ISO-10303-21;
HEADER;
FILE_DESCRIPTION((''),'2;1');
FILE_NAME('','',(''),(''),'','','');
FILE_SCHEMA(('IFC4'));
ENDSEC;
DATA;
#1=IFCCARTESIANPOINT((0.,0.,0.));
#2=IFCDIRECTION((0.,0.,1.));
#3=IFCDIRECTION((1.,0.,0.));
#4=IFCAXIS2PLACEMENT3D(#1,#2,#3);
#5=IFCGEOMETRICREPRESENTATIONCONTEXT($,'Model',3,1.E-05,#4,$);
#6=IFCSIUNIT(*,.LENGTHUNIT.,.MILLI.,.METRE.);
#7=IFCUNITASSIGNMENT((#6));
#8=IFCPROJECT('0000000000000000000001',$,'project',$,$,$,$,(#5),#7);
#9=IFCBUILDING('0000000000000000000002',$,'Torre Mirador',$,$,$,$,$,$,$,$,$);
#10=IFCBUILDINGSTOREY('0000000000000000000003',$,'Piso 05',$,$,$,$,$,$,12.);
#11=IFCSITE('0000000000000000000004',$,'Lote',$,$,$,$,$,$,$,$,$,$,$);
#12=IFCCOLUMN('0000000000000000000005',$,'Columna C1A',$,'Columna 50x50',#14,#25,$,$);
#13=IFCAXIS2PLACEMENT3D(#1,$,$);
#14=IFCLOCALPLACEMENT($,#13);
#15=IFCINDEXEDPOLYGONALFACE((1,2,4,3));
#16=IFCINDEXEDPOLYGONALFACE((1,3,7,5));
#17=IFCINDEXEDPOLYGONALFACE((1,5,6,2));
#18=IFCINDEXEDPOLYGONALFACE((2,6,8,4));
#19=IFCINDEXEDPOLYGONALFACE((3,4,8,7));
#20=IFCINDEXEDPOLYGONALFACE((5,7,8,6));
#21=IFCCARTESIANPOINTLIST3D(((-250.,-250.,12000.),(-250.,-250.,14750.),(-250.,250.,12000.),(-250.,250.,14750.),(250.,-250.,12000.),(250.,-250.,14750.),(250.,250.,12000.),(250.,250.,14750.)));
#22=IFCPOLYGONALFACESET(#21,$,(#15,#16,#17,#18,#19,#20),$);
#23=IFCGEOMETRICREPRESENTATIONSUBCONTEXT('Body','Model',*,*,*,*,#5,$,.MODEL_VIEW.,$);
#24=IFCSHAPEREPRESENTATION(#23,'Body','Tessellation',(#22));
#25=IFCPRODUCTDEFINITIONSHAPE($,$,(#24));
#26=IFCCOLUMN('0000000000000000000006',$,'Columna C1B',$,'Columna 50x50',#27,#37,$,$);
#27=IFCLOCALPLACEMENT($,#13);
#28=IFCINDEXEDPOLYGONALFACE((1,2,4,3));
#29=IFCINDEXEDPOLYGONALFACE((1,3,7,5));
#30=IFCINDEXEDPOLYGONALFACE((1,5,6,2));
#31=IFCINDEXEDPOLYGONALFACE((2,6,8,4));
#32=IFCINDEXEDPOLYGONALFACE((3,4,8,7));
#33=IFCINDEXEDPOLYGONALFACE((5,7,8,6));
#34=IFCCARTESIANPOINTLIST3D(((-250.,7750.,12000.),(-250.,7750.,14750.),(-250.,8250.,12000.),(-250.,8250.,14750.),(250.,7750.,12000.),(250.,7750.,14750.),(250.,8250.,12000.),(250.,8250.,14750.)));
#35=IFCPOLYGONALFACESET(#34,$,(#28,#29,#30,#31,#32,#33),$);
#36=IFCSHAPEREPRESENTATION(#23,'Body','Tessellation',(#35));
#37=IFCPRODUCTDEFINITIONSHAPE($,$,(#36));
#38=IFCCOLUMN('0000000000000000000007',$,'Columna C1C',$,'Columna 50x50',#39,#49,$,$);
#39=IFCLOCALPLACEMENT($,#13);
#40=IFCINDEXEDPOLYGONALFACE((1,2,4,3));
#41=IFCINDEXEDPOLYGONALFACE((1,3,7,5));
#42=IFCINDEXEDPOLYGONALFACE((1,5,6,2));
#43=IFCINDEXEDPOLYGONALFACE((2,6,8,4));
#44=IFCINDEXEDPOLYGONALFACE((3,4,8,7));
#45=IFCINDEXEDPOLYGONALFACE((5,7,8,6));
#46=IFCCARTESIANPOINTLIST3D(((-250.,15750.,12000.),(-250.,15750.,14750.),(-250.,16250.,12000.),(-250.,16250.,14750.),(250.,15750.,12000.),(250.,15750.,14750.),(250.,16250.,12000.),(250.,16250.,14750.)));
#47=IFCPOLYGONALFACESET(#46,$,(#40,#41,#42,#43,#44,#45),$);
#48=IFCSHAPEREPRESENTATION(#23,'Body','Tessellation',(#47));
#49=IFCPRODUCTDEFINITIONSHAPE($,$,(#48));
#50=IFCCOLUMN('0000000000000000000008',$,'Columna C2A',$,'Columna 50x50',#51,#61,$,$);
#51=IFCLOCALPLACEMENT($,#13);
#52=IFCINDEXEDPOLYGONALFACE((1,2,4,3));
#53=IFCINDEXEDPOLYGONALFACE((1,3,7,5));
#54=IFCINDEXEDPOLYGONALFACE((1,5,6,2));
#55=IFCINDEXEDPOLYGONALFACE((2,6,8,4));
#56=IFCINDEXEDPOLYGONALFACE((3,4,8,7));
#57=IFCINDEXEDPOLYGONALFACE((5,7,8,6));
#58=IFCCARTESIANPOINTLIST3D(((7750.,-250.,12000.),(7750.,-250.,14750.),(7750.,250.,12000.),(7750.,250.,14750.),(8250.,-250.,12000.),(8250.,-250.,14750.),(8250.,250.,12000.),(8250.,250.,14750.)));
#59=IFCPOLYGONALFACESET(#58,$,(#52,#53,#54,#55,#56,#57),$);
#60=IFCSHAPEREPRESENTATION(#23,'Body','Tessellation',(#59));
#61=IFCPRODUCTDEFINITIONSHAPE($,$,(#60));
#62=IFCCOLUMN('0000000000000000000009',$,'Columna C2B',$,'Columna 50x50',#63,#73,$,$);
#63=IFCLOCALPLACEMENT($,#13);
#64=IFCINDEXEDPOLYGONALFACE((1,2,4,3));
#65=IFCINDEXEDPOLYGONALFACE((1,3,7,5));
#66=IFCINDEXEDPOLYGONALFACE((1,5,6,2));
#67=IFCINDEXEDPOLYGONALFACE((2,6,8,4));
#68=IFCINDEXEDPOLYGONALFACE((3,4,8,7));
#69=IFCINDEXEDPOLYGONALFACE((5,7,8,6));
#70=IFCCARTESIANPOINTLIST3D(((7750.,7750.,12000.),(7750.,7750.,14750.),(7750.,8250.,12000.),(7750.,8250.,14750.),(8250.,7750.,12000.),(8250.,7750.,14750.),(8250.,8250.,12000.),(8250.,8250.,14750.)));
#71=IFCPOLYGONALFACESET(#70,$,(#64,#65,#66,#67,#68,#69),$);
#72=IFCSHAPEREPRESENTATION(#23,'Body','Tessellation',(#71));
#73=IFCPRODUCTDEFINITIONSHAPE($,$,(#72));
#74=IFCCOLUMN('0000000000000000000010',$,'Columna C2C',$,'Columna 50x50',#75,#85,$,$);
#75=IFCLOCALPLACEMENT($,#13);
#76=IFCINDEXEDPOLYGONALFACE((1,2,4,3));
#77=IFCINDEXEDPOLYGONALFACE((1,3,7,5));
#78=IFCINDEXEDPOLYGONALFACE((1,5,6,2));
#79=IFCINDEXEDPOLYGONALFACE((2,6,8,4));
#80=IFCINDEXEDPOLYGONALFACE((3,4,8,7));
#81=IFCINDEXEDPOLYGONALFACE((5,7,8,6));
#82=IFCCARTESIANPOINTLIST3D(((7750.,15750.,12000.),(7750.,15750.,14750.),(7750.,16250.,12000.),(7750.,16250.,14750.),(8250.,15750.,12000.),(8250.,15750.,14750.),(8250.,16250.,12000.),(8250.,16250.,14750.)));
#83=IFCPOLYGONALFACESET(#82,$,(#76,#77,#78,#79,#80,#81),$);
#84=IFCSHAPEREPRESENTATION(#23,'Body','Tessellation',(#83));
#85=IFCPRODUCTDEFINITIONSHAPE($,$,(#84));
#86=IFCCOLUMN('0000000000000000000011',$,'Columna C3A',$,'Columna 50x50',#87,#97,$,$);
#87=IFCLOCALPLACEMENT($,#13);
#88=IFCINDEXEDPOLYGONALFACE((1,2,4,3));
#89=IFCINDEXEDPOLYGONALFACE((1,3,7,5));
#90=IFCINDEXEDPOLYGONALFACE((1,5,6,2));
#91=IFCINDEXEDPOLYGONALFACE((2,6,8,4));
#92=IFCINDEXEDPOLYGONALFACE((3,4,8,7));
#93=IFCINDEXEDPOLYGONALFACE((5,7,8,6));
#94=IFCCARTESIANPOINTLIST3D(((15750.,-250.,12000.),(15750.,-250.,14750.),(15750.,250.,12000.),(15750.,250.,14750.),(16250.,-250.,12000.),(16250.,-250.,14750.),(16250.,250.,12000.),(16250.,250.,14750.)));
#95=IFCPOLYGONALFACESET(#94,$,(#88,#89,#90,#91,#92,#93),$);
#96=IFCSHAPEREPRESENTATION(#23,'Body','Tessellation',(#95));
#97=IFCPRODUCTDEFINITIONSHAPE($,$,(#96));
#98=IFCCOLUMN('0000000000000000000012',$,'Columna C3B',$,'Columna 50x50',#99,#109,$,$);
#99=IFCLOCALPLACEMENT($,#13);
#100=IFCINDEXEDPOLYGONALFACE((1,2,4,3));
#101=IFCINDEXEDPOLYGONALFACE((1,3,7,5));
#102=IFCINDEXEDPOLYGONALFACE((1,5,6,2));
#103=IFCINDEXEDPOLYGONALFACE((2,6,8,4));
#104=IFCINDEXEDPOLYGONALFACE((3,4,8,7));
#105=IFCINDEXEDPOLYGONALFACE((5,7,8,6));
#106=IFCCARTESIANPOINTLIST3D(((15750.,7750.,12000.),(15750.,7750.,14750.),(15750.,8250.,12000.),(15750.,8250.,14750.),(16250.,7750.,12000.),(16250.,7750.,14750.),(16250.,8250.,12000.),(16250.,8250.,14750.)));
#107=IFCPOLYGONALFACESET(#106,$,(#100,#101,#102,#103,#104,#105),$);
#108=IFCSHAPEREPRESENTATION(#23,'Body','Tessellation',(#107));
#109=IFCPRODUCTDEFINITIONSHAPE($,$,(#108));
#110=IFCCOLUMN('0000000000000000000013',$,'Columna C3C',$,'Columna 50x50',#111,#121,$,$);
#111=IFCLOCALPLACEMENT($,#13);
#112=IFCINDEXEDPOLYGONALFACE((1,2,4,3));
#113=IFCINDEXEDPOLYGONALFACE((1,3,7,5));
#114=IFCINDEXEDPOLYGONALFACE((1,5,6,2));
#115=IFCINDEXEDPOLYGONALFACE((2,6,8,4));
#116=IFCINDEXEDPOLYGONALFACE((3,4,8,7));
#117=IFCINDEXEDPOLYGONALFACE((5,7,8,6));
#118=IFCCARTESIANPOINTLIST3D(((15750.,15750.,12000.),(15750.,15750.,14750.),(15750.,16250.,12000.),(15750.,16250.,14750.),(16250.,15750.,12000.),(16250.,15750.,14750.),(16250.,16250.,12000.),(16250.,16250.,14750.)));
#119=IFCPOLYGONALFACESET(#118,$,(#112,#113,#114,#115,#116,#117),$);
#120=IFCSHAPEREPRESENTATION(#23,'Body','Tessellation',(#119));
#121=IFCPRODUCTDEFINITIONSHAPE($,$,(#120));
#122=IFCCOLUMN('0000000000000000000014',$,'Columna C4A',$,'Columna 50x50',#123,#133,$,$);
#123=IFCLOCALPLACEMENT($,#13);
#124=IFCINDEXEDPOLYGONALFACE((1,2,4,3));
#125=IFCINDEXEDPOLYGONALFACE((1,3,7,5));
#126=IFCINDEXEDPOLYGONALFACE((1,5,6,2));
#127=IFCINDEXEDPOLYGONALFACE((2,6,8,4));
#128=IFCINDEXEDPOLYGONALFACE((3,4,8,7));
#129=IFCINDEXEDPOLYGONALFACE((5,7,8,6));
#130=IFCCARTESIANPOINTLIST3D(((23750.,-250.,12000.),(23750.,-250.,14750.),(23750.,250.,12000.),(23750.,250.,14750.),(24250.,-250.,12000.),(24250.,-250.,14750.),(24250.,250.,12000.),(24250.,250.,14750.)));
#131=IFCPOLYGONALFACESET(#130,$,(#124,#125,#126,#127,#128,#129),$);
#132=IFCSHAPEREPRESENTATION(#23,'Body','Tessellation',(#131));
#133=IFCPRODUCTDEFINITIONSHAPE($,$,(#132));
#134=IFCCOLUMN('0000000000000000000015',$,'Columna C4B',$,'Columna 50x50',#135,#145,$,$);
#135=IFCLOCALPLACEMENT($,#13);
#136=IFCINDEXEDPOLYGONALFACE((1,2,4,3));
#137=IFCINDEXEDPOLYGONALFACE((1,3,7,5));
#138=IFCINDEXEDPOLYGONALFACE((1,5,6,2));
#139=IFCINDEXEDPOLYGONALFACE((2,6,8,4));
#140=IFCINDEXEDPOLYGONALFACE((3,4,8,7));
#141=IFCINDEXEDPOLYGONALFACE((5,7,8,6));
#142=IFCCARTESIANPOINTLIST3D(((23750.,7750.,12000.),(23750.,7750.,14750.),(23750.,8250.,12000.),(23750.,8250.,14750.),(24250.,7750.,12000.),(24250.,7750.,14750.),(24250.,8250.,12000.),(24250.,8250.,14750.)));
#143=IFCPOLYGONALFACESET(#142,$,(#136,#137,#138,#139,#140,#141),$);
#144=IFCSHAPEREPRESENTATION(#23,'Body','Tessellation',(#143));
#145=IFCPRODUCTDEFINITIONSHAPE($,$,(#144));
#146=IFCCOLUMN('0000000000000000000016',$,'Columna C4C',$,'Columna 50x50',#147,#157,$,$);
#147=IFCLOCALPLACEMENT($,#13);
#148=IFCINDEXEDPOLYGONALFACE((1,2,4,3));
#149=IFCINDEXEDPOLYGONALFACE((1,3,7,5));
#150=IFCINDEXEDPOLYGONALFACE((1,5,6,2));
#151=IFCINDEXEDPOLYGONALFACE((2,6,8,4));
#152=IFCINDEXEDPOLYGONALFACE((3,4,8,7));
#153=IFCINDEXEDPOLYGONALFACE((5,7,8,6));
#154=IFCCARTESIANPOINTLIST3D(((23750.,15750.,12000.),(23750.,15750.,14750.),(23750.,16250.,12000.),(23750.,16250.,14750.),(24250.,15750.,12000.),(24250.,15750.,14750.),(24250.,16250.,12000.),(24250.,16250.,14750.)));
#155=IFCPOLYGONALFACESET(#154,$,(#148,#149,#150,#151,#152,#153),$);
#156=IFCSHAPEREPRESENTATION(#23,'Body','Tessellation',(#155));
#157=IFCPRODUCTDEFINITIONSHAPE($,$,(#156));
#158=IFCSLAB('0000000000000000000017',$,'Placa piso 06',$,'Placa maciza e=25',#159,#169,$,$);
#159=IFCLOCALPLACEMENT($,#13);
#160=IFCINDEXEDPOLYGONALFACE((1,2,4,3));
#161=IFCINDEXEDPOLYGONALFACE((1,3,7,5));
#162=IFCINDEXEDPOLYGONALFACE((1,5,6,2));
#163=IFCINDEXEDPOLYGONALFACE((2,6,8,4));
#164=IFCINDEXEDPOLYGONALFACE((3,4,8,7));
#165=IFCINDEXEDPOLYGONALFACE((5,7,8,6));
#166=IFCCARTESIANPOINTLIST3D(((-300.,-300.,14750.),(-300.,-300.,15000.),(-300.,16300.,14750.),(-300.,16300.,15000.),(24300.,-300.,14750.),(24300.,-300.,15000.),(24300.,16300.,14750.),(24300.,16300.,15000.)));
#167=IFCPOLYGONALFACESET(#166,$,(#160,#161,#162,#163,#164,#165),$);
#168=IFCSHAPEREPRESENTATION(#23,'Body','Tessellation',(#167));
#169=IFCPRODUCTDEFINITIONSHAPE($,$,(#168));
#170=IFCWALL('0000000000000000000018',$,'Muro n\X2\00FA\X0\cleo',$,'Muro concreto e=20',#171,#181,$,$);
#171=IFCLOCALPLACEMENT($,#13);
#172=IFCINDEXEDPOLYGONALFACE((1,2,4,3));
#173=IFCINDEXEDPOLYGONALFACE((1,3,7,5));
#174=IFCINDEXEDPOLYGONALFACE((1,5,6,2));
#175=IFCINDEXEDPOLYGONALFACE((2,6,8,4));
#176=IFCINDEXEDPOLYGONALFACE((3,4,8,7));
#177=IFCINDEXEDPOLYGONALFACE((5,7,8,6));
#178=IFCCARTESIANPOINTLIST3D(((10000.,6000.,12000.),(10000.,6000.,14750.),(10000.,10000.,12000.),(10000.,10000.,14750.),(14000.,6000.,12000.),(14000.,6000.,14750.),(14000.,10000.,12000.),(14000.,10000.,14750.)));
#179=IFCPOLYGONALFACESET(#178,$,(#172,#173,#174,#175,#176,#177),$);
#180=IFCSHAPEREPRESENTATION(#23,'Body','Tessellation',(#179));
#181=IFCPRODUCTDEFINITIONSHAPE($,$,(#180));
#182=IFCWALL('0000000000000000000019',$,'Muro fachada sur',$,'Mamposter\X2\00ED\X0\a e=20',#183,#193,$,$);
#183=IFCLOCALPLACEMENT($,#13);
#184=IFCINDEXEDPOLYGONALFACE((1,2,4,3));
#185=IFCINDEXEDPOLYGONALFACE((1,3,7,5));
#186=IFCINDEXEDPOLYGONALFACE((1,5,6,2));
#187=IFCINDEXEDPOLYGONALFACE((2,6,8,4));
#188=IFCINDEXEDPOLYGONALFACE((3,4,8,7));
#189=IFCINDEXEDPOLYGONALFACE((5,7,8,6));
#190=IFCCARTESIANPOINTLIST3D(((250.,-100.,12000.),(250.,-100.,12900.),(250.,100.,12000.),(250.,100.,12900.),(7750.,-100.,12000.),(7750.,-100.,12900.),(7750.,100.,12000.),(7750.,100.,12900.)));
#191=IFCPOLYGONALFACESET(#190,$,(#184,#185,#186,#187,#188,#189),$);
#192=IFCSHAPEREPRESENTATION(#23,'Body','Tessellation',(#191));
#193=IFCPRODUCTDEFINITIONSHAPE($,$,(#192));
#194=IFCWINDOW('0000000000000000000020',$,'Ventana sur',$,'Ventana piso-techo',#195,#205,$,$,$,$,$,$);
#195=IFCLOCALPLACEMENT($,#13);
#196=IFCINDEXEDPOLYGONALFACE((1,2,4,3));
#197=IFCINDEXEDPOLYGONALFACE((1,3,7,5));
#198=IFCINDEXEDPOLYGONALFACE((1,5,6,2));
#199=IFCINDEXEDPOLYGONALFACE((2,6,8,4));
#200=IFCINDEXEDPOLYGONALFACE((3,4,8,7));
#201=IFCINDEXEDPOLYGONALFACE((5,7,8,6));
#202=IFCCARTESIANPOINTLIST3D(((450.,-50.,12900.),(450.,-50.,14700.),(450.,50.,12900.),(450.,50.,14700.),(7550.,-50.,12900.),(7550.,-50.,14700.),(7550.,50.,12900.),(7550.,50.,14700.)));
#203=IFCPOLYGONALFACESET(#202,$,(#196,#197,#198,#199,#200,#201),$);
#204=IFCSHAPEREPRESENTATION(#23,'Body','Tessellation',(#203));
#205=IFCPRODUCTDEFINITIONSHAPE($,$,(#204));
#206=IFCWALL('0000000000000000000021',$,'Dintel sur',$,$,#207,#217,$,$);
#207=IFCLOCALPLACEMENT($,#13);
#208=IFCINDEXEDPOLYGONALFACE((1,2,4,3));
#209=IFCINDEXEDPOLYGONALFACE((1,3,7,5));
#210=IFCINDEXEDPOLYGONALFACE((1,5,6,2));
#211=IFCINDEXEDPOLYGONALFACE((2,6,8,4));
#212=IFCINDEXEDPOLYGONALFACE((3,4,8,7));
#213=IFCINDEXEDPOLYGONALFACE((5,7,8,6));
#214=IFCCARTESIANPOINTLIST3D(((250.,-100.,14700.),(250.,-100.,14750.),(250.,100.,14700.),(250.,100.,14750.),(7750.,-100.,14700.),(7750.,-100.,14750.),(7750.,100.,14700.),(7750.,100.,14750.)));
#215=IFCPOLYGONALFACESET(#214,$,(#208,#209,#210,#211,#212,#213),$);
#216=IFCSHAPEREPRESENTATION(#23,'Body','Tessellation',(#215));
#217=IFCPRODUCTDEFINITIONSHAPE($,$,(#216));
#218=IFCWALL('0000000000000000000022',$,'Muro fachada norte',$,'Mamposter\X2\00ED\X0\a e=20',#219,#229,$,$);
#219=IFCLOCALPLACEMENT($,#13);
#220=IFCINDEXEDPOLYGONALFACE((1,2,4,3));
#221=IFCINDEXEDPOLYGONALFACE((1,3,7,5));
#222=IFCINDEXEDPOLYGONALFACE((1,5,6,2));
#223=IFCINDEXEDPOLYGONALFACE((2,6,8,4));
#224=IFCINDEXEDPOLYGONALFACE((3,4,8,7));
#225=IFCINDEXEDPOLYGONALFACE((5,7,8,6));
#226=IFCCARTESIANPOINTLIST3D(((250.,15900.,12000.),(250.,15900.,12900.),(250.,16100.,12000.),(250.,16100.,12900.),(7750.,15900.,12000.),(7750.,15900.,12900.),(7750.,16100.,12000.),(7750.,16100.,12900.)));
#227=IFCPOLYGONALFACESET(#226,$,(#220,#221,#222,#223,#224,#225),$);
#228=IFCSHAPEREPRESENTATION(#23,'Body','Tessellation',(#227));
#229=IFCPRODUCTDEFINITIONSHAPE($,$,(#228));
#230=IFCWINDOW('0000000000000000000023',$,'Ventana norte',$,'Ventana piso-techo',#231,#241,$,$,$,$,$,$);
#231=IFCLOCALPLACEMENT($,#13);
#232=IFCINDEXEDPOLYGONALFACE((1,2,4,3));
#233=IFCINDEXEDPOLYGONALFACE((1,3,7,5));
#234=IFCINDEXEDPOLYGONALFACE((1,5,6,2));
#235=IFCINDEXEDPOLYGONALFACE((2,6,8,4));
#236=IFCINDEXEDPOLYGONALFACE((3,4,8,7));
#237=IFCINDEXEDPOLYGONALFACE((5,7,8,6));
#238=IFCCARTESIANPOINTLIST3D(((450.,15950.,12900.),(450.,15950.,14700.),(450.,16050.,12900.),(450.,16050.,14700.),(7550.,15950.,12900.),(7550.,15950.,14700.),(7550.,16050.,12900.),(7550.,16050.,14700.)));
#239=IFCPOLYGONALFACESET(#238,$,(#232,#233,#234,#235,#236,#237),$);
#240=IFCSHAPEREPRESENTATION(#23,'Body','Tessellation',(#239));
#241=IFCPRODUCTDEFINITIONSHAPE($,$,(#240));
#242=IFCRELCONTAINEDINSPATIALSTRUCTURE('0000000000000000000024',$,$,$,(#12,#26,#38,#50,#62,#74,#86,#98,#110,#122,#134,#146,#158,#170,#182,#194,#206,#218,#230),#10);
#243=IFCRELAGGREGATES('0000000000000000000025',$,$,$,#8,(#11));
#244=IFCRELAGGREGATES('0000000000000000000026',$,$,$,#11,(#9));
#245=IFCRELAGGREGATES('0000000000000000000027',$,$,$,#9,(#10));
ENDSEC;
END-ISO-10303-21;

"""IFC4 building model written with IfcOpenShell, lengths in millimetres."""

from ifc_helpers import new_model, si_unit, frame, origin_with_axes, place, context, subcontext, project, spatial, indexed_curve, outline, extrude, element, save


model = new_model("IFC4")

# Units and contexts
model_context = context("Model", 3, precision=1e-05, world=origin_with_axes())
body_context = subcontext(model_context, "Body", "Model", "MODEL_VIEW")
ifc_project = project(units=[si_unit("LENGTHUNIT", "METRE", prefix="MILLI")], contexts=[model_context])

# Site, building, storey
site = spatial("IfcSite", under=ifc_project, Name="Lote")
building = spatial("IfcBuilding", under=site, Name="Torre Mirador")
storey = spatial("IfcBuildingStorey", under=building, Name="Piso 05", Elevation=12.0)

# Columns
for number, where, z_axis, x_axis, name in (
    (1, (-250.0, -250.0, 12000.0), (0.0, 0.0, 1.0), (1.0, 0.0, 0.0), "Columna C1A"),
    (2, (-250.0, 7750.0, 12000.0), (0.0, 0.0, 1.0), (1.0, 0.0, 0.0), "Columna C1B"),
    (3, (-250.0, 15750.0, 12000.0), (0.0, 0.0, 1.0), (1.0, 0.0, 0.0), "Columna C1C"),
    (4, (7750.0, -250.0, 12000.0), (0.0, 0.0, 1.0), (1.0, 0.0, 0.0), "Columna C2A"),
    (5, (7750.0, 7750.0, 12000.0), (0.0, 0.0, 1.0), (1.0, 0.0, 0.0), "Columna C2B"),
    (6, (7750.0, 15750.0, 12000.0), (0.0, 0.0, 1.0), (1.0, 0.0, 0.0), "Columna C2C"),
    (7, (15750.0, -250.0, 12000.0), (0.0, 0.0, 1.0), (1.0, 0.0, 0.0), "Columna C3A"),
    (8, (15750.0, 7750.0, 12000.0), (0.0, 0.0, 1.0), (1.0, 0.0, 0.0), "Columna C3B"),
    (9, (15750.0, 15750.0, 12000.0), (0.0, 0.0, 1.0), (1.0, 0.0, 0.0), "Columna C3C"),
    (10, (23750.0, -250.0, 12000.0), (0.0, 0.0, 1.0), (1.0, 0.0, 0.0), "Columna C4A"),
    (11, (23750.0, 7750.0, 12000.0), (0.0, 0.0, 1.0), (1.0, 0.0, 0.0), "Columna C4B"),
    (12, (23750.0, 15750.0, 12000.0), (0.0, 0.0, 1.0), (1.0, 0.0, 0.0), "Columna C4C"),
):
    element("IfcColumn", number, at=place(None, frame(where, z_axis=z_axis, x_axis=x_axis)), inside=storey, Name=name, ObjectType="Columna 50x50", context=body_context, shape_type="SweptSolid", body=[
        extrude(outline(indexed_curve([(0.0, 0.0), (0.0, 500.0), (500.0, 500.0), (500.0, 0.0), (0.0, 0.0)], self_intersect=False)), origin_with_axes(), (0.0, 0.0, 1.0), 2750.0),
    ])

# Slab
slab_placement = place(None, frame((-300.0, -300.0, 14750.0), z_axis=(0.0, 0.0, 1.0), x_axis=(1.0, 0.0, 0.0)))
element("IfcSlab", 13, at=slab_placement, inside=storey, Name="Placa piso 06", ObjectType="Placa maciza e=25", context=body_context, shape_type="SweptSolid", body=[
    extrude(outline(indexed_curve([(0.0, 0.0), (0.0, 16600.0), (24600.0, 16600.0), (24600.0, 0.0), (0.0, 0.0)], self_intersect=False)), origin_with_axes(), (0.0, 0.0, 1.0), 250.0),
])

# Walls
wall_1_placement = place(None, frame((10000.0, 6000.0, 12000.0), z_axis=(0.0, 0.0, 1.0), x_axis=(1.0, 0.0, 0.0)))
element("IfcWall", 14, at=wall_1_placement, inside=storey, Name="Muro núcleo", ObjectType="Muro concreto e=20", context=body_context, shape_type="SweptSolid", body=[
    extrude(outline(indexed_curve([(0.0, 0.0), (0.0, 4000.0), (4000.0, 4000.0), (4000.0, 0.0), (0.0, 0.0)], self_intersect=False)), origin_with_axes(), (0.0, 0.0, 1.0), 2750.0),
])
wall_2_placement = place(None, frame((250.0, -100.0, 12000.0), z_axis=(0.0, 0.0, 1.0), x_axis=(1.0, 0.0, 0.0)))
element("IfcWall", 15, at=wall_2_placement, inside=storey, Name="Muro fachada sur", ObjectType="Mampostería e=20", context=body_context, shape_type="SweptSolid", body=[
    extrude(outline(indexed_curve([(0.0, 0.0), (0.0, 200.0), (7500.0, 200.0), (7500.0, 0.0), (0.0, 0.0)], self_intersect=False)), origin_with_axes(), (0.0, 0.0, 1.0), 900.0),
])

# Window
window_1_placement = place(None, frame((450.0, -50.0, 12900.0), z_axis=(0.0, 0.0, 1.0), x_axis=(1.0, 0.0, 0.0)))
element("IfcWindow", 16, at=window_1_placement, inside=storey, Name="Ventana sur", ObjectType="Ventana piso-techo", context=body_context, shape_type="SweptSolid", body=[
    extrude(outline(indexed_curve([(0.0, 0.0), (0.0, 100.0), (7100.0, 100.0), (7100.0, 0.0), (0.0, 0.0)], self_intersect=False)), origin_with_axes(), (0.0, 0.0, 1.0), 1800.0),
])

# Walls
wall_3_placement = place(None, frame((250.0, -100.0, 14700.0), z_axis=(0.0, 0.0, 1.0), x_axis=(1.0, 0.0, 0.0)))
element("IfcWall", 17, at=wall_3_placement, inside=storey, Name="Dintel sur", context=body_context, shape_type="SweptSolid", body=[
    extrude(outline(indexed_curve([(0.0, 0.0), (0.0, 200.0), (7500.0, 200.0), (7500.0, 0.0), (0.0, 0.0)], self_intersect=False)), origin_with_axes(), (0.0, 0.0, 1.0), 50.0),
])
wall_4_placement = place(None, frame((250.0, 15900.0, 12000.0), z_axis=(0.0, 0.0, 1.0), x_axis=(1.0, 0.0, 0.0)))
element("IfcWall", 18, at=wall_4_placement, inside=storey, Name="Muro fachada norte", ObjectType="Mampostería e=20", context=body_context, shape_type="SweptSolid", body=[
    extrude(outline(indexed_curve([(0.0, 0.0), (0.0, 200.0), (7500.0, 200.0), (7500.0, 0.0), (0.0, 0.0)], self_intersect=False)), origin_with_axes(), (0.0, 0.0, 1.0), 900.0),
])

# Window
window_2_placement = place(None, frame((450.0, 15950.0, 12900.0), z_axis=(0.0, 0.0, 1.0), x_axis=(1.0, 0.0, 0.0)))
element("IfcWindow", 19, at=window_2_placement, inside=storey, Name="Ventana norte", ObjectType="Ventana piso-techo", context=body_context, shape_type="SweptSolid", body=[
    extrude(outline(indexed_curve([(0.0, 0.0), (0.0, 100.0), (7100.0, 100.0), (7100.0, 0.0), (0.0, 0.0)], self_intersect=False)), origin_with_axes(), (0.0, 0.0, 1.0), 1800.0),
])

save(model, "model.ifc")
